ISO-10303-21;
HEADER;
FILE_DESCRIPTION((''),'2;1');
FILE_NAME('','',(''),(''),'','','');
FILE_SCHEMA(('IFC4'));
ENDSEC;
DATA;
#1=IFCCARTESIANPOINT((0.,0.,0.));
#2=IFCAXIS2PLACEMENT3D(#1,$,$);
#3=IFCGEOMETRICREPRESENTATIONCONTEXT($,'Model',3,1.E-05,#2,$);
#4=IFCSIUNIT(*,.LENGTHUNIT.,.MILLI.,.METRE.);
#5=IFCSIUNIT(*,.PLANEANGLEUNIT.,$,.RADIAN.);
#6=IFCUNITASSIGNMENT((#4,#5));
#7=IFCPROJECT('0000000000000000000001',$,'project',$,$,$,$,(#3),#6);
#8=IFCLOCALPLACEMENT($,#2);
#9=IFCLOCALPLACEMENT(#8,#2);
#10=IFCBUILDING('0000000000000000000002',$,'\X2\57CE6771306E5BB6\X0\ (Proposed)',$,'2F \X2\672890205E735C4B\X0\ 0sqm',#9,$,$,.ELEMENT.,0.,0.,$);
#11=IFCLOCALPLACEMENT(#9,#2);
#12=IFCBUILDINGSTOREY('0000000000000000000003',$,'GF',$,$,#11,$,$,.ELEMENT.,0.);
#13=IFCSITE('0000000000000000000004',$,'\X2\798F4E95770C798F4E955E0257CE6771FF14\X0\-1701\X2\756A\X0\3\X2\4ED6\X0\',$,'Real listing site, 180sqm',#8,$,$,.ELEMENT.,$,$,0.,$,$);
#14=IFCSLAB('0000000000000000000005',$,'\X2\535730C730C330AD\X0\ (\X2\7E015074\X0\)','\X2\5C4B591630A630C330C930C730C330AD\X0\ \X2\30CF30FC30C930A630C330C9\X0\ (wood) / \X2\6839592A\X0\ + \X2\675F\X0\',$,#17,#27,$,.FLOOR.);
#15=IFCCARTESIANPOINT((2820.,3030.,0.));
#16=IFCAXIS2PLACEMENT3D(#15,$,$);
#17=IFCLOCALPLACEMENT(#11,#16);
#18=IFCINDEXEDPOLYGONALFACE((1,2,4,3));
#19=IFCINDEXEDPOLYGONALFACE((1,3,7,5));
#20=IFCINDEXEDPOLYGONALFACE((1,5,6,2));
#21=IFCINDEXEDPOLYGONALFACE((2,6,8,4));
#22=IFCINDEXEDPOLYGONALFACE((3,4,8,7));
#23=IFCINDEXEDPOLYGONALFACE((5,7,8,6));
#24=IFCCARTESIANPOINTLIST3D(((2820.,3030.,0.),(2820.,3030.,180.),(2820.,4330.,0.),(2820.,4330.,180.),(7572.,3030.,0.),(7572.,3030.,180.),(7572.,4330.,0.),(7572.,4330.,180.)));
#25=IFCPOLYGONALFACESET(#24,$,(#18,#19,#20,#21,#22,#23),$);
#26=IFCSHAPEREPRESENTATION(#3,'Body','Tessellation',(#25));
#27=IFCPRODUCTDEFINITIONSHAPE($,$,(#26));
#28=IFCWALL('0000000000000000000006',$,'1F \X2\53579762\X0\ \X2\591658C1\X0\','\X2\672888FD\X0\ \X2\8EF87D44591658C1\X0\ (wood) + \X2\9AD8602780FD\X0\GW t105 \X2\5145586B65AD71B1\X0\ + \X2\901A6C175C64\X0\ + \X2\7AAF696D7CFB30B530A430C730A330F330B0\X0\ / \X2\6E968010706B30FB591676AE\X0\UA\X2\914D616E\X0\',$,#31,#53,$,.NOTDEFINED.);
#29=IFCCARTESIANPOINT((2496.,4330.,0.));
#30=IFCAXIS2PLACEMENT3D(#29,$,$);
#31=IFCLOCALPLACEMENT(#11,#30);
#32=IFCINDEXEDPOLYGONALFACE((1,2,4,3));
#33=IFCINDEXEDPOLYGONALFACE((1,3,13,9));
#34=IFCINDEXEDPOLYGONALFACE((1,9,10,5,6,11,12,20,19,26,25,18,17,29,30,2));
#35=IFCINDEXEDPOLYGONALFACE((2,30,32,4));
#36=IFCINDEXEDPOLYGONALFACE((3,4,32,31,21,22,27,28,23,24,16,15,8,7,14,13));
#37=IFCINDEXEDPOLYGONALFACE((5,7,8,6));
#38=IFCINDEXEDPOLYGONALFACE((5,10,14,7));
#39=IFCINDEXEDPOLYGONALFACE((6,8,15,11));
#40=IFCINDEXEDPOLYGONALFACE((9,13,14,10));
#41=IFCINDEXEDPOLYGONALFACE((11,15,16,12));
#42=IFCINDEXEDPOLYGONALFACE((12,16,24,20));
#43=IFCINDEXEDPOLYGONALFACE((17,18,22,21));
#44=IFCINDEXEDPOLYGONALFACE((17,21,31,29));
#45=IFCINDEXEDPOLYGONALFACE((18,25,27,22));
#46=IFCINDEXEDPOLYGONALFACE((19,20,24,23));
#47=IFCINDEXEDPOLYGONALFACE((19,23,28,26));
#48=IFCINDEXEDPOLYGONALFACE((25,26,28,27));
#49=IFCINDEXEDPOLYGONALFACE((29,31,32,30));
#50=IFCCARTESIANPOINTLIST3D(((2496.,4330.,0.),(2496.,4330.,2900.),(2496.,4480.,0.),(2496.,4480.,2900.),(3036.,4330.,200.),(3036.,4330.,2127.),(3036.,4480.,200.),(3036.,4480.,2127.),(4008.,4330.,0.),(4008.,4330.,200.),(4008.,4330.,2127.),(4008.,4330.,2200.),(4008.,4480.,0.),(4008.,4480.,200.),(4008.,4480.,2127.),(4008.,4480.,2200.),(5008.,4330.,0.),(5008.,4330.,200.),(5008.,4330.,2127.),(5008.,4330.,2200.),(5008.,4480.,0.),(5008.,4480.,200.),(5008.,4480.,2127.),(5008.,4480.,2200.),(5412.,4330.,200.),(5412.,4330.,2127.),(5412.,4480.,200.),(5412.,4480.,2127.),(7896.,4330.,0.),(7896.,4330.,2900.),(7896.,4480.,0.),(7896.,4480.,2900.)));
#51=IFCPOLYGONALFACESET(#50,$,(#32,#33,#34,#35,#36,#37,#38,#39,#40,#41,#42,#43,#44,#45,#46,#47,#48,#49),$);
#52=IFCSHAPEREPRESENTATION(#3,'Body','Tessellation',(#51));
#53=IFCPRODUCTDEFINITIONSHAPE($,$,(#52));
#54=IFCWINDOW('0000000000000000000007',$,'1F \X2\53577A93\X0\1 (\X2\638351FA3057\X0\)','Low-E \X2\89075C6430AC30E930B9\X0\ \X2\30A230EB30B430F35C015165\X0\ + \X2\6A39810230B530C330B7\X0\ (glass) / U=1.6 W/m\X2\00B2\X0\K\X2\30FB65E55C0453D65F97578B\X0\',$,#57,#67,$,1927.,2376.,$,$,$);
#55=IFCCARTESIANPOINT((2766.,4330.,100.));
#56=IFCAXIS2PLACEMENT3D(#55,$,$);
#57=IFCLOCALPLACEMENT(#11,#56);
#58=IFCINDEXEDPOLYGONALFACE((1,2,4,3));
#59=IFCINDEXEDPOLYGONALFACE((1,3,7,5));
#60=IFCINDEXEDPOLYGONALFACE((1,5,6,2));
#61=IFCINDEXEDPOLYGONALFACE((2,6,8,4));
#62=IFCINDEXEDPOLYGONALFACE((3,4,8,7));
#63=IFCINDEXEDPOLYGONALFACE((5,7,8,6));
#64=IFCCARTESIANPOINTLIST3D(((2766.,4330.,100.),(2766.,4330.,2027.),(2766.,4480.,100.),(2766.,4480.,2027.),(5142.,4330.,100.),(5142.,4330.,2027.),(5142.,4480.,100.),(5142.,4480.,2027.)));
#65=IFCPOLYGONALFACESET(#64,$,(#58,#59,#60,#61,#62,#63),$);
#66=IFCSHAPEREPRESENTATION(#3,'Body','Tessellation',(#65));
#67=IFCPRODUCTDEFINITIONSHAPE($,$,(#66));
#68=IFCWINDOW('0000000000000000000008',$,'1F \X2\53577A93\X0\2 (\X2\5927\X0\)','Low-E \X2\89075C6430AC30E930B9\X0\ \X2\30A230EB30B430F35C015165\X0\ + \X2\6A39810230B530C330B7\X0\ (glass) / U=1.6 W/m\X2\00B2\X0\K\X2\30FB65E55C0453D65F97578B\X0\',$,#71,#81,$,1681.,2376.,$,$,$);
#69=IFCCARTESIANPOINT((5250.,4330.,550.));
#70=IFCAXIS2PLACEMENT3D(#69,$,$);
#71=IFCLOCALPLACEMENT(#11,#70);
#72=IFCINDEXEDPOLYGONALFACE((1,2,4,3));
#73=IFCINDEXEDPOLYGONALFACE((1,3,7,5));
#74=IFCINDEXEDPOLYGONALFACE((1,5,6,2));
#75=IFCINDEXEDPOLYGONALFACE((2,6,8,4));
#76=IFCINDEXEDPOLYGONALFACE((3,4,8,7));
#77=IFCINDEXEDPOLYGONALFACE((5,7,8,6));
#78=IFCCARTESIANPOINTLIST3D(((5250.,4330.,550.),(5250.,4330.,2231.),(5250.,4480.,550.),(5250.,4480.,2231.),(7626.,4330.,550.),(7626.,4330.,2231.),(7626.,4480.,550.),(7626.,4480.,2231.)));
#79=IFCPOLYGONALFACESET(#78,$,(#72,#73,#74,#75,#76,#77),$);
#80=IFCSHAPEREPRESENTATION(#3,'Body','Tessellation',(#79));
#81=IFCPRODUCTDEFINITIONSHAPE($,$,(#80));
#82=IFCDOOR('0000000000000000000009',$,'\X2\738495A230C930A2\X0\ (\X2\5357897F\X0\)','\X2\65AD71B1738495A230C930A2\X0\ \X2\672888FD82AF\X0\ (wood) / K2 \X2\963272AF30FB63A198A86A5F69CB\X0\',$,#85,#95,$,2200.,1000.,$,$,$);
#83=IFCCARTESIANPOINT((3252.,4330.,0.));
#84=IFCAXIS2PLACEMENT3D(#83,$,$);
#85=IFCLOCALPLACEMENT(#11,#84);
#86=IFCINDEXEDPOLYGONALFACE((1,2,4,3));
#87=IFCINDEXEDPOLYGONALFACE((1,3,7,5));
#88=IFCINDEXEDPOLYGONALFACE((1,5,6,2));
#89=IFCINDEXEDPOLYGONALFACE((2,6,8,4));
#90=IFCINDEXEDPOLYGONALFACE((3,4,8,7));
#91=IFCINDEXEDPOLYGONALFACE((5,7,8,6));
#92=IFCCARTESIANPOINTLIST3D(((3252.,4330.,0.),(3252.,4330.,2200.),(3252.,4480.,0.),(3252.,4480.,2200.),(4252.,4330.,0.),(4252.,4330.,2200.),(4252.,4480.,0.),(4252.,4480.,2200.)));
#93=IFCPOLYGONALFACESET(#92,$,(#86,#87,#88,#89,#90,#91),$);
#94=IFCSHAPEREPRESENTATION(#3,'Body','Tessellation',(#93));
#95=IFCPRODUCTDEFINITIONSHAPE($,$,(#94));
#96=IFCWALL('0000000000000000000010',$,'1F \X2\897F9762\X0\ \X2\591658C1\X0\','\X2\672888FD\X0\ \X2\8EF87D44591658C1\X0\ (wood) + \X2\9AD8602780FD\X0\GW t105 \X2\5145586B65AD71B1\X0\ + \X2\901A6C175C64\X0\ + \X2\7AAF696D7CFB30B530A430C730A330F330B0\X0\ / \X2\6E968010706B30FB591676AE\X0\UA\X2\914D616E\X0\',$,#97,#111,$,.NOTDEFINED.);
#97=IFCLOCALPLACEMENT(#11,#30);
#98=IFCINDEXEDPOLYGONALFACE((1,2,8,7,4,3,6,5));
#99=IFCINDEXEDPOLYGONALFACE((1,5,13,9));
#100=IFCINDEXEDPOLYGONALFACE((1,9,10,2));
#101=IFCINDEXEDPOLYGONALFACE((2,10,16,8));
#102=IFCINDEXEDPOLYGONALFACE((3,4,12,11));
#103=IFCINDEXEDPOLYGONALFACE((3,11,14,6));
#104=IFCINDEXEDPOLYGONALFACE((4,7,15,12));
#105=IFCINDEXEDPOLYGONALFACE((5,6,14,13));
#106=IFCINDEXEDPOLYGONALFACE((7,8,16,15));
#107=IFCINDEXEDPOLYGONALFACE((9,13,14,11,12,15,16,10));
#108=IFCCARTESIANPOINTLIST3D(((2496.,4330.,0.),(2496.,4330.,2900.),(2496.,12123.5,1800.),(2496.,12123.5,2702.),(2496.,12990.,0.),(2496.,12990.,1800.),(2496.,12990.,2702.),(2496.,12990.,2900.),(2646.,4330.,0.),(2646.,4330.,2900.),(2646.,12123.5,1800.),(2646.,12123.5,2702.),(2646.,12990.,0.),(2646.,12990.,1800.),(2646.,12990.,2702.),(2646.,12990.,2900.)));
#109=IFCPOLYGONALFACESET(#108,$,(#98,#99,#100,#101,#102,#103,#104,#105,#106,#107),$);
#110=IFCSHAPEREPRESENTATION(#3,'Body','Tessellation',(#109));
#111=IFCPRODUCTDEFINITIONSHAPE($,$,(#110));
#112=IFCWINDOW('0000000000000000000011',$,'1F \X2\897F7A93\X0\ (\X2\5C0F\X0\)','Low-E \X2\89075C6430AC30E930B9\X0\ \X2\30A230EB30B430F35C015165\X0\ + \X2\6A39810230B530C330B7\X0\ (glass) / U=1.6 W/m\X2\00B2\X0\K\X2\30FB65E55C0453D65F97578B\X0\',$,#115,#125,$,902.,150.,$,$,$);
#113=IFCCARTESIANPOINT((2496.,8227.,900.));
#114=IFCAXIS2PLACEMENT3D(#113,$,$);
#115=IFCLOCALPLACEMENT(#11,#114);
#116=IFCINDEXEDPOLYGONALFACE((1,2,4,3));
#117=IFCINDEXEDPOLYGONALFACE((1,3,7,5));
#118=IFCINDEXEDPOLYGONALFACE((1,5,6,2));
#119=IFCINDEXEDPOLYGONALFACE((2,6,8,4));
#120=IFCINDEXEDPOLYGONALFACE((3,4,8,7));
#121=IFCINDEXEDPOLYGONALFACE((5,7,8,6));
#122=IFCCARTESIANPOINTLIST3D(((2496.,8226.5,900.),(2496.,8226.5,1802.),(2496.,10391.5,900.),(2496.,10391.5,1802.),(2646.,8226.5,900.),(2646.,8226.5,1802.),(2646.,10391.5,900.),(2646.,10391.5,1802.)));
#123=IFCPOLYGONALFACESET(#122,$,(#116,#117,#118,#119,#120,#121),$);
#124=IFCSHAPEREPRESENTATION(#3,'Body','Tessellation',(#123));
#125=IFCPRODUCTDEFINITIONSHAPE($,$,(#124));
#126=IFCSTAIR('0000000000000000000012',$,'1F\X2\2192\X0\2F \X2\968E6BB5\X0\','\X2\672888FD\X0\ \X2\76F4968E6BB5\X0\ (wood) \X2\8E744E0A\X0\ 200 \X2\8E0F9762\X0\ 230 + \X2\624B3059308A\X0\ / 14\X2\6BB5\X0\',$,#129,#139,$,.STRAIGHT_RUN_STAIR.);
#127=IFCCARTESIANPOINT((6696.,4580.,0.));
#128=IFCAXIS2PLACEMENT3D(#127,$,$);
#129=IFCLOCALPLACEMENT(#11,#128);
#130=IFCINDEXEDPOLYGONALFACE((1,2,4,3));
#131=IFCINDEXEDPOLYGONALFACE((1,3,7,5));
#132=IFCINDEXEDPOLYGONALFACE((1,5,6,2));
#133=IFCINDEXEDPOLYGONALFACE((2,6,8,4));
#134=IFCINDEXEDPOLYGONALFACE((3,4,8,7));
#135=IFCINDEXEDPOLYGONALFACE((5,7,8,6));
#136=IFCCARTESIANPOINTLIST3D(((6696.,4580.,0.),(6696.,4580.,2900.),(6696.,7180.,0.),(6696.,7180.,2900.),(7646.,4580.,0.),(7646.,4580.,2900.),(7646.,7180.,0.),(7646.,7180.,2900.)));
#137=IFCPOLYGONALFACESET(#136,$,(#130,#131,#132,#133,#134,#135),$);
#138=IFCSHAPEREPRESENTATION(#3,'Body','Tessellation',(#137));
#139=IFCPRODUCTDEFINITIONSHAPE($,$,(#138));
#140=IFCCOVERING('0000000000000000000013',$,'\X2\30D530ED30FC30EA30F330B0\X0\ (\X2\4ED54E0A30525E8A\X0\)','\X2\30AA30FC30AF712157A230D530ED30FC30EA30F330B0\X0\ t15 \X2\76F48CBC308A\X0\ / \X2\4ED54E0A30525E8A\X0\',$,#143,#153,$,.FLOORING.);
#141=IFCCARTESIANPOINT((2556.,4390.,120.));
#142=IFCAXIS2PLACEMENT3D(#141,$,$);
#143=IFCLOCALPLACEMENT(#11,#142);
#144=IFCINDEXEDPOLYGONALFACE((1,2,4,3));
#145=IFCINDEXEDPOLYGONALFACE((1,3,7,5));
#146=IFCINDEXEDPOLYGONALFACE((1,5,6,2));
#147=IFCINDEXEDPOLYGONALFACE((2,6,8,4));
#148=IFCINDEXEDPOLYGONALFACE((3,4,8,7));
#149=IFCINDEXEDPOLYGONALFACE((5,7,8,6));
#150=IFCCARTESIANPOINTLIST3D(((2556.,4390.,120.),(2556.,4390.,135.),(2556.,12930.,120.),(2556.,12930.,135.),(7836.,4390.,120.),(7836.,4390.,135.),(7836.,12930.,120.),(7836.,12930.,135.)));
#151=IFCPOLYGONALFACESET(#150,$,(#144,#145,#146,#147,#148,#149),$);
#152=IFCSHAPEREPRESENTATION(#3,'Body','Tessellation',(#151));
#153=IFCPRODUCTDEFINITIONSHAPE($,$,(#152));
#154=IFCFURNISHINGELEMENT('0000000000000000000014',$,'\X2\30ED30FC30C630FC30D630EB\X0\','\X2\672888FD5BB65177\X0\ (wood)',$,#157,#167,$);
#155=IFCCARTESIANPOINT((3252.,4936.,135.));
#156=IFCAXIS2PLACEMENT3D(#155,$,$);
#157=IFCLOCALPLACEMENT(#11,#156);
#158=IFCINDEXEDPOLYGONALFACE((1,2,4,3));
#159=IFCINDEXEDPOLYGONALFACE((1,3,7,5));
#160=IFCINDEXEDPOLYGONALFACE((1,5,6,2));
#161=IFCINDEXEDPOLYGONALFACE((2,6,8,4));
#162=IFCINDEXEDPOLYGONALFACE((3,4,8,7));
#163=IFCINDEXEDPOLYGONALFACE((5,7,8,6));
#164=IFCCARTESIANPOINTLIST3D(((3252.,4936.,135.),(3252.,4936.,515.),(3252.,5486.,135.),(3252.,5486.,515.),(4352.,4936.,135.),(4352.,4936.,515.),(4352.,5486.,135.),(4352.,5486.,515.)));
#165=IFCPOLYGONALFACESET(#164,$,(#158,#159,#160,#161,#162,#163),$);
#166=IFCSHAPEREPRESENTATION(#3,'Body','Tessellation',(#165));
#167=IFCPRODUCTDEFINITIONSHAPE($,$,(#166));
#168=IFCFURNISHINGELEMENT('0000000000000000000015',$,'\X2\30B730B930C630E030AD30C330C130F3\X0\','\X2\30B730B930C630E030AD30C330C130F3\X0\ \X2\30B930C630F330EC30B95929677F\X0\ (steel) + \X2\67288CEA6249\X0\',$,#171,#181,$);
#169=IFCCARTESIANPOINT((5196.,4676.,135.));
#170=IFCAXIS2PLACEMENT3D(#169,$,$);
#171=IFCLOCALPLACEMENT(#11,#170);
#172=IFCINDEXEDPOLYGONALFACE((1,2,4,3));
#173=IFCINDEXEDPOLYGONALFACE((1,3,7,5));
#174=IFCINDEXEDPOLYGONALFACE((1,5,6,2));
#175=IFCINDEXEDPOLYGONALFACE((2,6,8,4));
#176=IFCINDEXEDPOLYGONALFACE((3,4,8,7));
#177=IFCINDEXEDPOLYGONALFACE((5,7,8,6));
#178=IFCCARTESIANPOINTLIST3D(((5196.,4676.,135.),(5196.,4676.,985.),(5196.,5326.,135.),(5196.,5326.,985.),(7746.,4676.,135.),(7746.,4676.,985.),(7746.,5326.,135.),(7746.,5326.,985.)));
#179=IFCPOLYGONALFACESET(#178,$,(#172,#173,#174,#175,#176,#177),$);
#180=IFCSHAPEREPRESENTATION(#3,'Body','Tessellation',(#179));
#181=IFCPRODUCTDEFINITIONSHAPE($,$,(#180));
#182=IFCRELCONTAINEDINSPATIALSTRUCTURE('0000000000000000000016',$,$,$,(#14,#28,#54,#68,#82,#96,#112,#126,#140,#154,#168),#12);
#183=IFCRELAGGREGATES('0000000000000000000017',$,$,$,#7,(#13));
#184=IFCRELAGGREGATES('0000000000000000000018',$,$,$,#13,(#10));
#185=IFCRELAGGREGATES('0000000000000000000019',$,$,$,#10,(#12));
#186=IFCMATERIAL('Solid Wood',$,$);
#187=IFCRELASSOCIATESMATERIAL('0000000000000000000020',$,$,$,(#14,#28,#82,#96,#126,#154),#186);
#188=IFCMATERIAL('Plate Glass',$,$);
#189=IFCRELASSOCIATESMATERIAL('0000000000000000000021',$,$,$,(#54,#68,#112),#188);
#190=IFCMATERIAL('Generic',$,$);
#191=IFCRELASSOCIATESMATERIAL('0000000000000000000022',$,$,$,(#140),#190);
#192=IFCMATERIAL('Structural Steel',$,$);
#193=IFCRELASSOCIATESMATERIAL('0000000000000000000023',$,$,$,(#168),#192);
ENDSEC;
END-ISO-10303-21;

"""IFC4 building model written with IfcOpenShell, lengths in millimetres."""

from ifc_helpers import new_model, si_unit, frame, frame_2d, origin, place, context, project, spatial, rectangle, extrude, material, element, fill, save


model = new_model("IFC4")

# Units and contexts
model_context = context("Model", 3, precision=1e-05, world=origin())
ifc_project = project(units=[si_unit("LENGTHUNIT", "METRE", prefix="MILLI"), si_unit("PLANEANGLEUNIT", "RADIAN")], contexts=[model_context])

# Site, building, storey
site_placement = place(None, origin())
site = spatial("IfcSite", under=ifc_project, at=site_placement, Name="福井県福井市城東４-1701番3他", ObjectType="Real listing site, 180sqm", CompositionType="ELEMENT", RefElevation=0.0)
building_placement = place(site_placement, origin())
building = spatial("IfcBuilding", under=site, at=building_placement, Name="城東の家 (Proposed)", ObjectType="2F 木造平屋 0sqm", CompositionType="ELEMENT", ElevationOfRefHeight=0.0, ElevationOfTerrain=0.0)
storey_placement = place(building_placement, origin())
storey = spatial("IfcBuildingStorey", under=building, at=storey_placement, Name="GF", CompositionType="ELEMENT", Elevation=0.0)

# Slab
ifc_material_1 = material(Name="Solid Wood")
slab_1_placement = place(storey_placement, frame((2820.0, 3030.0, 0.0)))
element("IfcSlab", 1, at=slab_1_placement, inside=storey, material=ifc_material_1, Name="南デッキ (縁側)", Description="屋外ウッドデッキ ハードウッド (wood) / 根太 + 束", PredefinedType="FLOOR", context=model_context, shape_type="SweptSolid", body=[
    extrude(rectangle(XDim=4752.0, YDim=1300.0, at=frame_2d((2376.0, 650.0))), frame((2820.0, 3030.0, 0.0)), (0.0, 0.0, 1.0), 180.0),
])

# Wall, openings, windows, door
wall_1_placement = place(storey_placement, frame((2496.0, 4330.0, 0.0)))
wall_1 = element("IfcWall", 2, at=wall_1_placement, inside=storey, material=ifc_material_1, Name="1F 南面 外壁", Description="木製 軸組外壁 (wood) + 高性能GW t105 充填断熱 + 通気層 + 窯業系サイディング / 準耐火・外皮UA配慮", PredefinedType="NOTDEFINED", context=model_context, shape_type="SweptSolid", body=[
    extrude(rectangle(XDim=5400.0, YDim=150.0, at=frame_2d((2700.0, 75.0))), frame((2496.0, 4330.0, 0.0)), (0.0, 0.0, 1.0), 2900.0),
])
opening_1_placement = place(storey_placement, frame((2766.0, 4330.0, 100.0)))
opening_1 = element("IfcOpeningElement", 3, at=opening_1_placement, cuts=wall_1, PredefinedType="NOTDEFINED", context=model_context, shape_type="SweptSolid", body=[
    extrude(rectangle(XDim=2376.0, YDim=150.0, at=frame_2d((1188.0, 75.0))), frame((2766.0, 4330.0, 100.0)), (0.0, 0.0, 1.0), 1927.0),
])
opening_2_placement = place(storey_placement, frame((5250.0, 4330.0, 550.0)))
opening_2 = element("IfcOpeningElement", 4, at=opening_2_placement, cuts=wall_1, PredefinedType="NOTDEFINED", context=model_context, shape_type="SweptSolid", body=[
    extrude(rectangle(XDim=2376.0, YDim=150.0, at=frame_2d((1188.0, 75.0))), frame((5250.0, 4330.0, 550.0)), (0.0, 0.0, 1.0), 1681.0),
])
opening_3_placement = place(storey_placement, frame((3252.0, 4330.0, 0.0)))
opening_3 = element("IfcOpeningElement", 5, at=opening_3_placement, cuts=wall_1, PredefinedType="NOTDEFINED", context=model_context, shape_type="SweptSolid", body=[
    extrude(rectangle(XDim=1000.0, YDim=150.0, at=frame_2d((500.0, 75.0))), frame((3252.0, 4330.0, 0.0)), (0.0, 0.0, 1.0), 2200.0),
])
ifc_material_2 = material(Name="Plate Glass")
window_1_placement = place(storey_placement, frame((2766.0, 4330.0, 100.0)))
window_1 = element("IfcWindow", 6, at=window_1_placement, inside=storey, material=ifc_material_2, Name="1F 南窓1 (掃出し)", Description="Low-E 複層ガラス アルゴン封入 + 樹脂サッシ (glass) / U=1.6 W/m²K・日射取得型", OverallHeight=1927.0, OverallWidth=2376.0, context=model_context, shape_type="SweptSolid", body=[
    extrude(rectangle(XDim=2376.0, YDim=150.0, at=frame_2d((1188.0, 75.0))), frame((2766.0, 4330.0, 100.0)), (0.0, 0.0, 1.0), 1927.0),
])
fill(opening_1, window_1)
window_2_placement = place(storey_placement, frame((5250.0, 4330.0, 550.0)))
window_2 = element("IfcWindow", 7, at=window_2_placement, inside=storey, material=ifc_material_2, Name="1F 南窓2 (大)", Description="Low-E 複層ガラス アルゴン封入 + 樹脂サッシ (glass) / U=1.6 W/m²K・日射取得型", OverallHeight=1681.0, OverallWidth=2376.0, context=model_context, shape_type="SweptSolid", body=[
    extrude(rectangle(XDim=2376.0, YDim=150.0, at=frame_2d((1188.0, 75.0))), frame((5250.0, 4330.0, 550.0)), (0.0, 0.0, 1.0), 1681.0),
])
fill(opening_2, window_2)
door_placement = place(storey_placement, frame((3252.0, 4330.0, 0.0)))
door = element("IfcDoor", 8, at=door_placement, inside=storey, material=ifc_material_1, Name="玄関ドア (南西)", Description="断熱玄関ドア 木製芯 (wood) / K2 防犯・採風機構", OverallHeight=2200.0, OverallWidth=1000.0, context=model_context, shape_type="SweptSolid", body=[
    extrude(rectangle(XDim=1000.0, YDim=150.0, at=frame_2d((500.0, 75.0))), frame((3252.0, 4330.0, 0.0)), (0.0, 0.0, 1.0), 2200.0),
])
fill(opening_3, door)

# Wall, opening, window
wall_2_placement = place(storey_placement, frame((2496.0, 4330.0, 0.0)))
wall_2 = element("IfcWall", 9, at=wall_2_placement, inside=storey, material=ifc_material_1, Name="1F 西面 外壁", Description="木製 軸組外壁 (wood) + 高性能GW t105 充填断熱 + 通気層 + 窯業系サイディング / 準耐火・外皮UA配慮", PredefinedType="NOTDEFINED", context=model_context, shape_type="SweptSolid", body=[
    extrude(rectangle(XDim=150.0, YDim=8660.0, at=frame_2d((75.0, 4330.0))), frame((2496.0, 4330.0, 0.0)), (0.0, 0.0, 1.0), 2900.0),
])
opening_4_placement = place(storey_placement, frame((2496.0, 8227.0, 900.0)))
opening_4 = element("IfcOpeningElement", 10, at=opening_4_placement, cuts=wall_2, PredefinedType="NOTDEFINED", context=model_context, shape_type="SweptSolid", body=[
    extrude(rectangle(XDim=150.0, YDim=2165.0, at=frame_2d((75.0, 1082.0))), frame((2496.0, 8227.0, 900.0)), (0.0, 0.0, 1.0), 902.0),
])
window_3_placement = place(storey_placement, frame((2496.0, 8227.0, 900.0)))
window_3 = element("IfcWindow", 11, at=window_3_placement, inside=storey, material=ifc_material_2, Name="1F 西窓 (小)", Description="Low-E 複層ガラス アルゴン封入 + 樹脂サッシ (glass) / U=1.6 W/m²K・日射取得型", OverallHeight=902.0, OverallWidth=150.0, context=model_context, shape_type="SweptSolid", body=[
    extrude(rectangle(XDim=150.0, YDim=2165.0, at=frame_2d((75.0, 1082.0))), frame((2496.0, 8227.0, 900.0)), (0.0, 0.0, 1.0), 902.0),
])
fill(opening_4, window_3)

# Stair
stair_placement = place(storey_placement, frame((6696.0, 4580.0, 0.0)))
element("IfcStair", 12, at=stair_placement, inside=storey, material=ifc_material_1, Name="1F→2F 階段", Description="木製 直階段 (wood) 蹴上 200 踏面 230 + 手すり / 14段", PredefinedType="STRAIGHT_RUN_STAIR", context=model_context, shape_type="SweptSolid", body=[
    extrude(rectangle(XDim=950.0, YDim=2600.0, at=frame_2d((475.0, 1300.0))), frame((6696.0, 4580.0, 0.0)), (0.0, 0.0, 1.0), 2900.0),
])

# Covering
ifc_material_3 = material(Name="Generic")
covering_placement = place(storey_placement, frame((2556.0, 4390.0, 120.0)))
element("IfcCovering", 13, at=covering_placement, inside=storey, material=ifc_material_3, Name="フローリング (仕上げ床)", Description="オーク無垢フローリング t15 直貼り / 仕上げ床", PredefinedType="FLOORING", context=model_context, shape_type="SweptSolid", body=[
    extrude(rectangle(XDim=5280.0, YDim=8540.0, at=frame_2d((2640.0, 4270.0))), frame((2556.0, 4390.0, 120.0)), (0.0, 0.0, 1.0), 15.0),
])

# Furnishing elements
furnishing_1_placement = place(storey_placement, frame((3252.0, 4936.0, 135.0)))
element("IfcFurnishingElement", 14, at=furnishing_1_placement, inside=storey, material=ifc_material_1, Name="ローテーブル", Description="木製家具 (wood)", context=model_context, shape_type="SweptSolid", body=[
    extrude(rectangle(XDim=1100.0, YDim=550.0, at=frame_2d((550.0, 275.0))), frame((3252.0, 4936.0, 135.0)), (0.0, 0.0, 1.0), 380.0),
])
ifc_material_4 = material(Name="Structural Steel")
furnishing_2_placement = place(storey_placement, frame((5196.0, 4676.0, 135.0)))
element("IfcFurnishingElement", 15, at=furnishing_2_placement, inside=storey, material=ifc_material_4, Name="システムキッチン", Description="システムキッチン ステンレス天板 (steel) + 木質扉", context=model_context, shape_type="SweptSolid", body=[
    extrude(rectangle(XDim=2550.0, YDim=650.0, at=frame_2d((1275.0, 325.0))), frame((5196.0, 4676.0, 135.0)), (0.0, 0.0, 1.0), 850.0),
])

save(model, "model.ifc")
